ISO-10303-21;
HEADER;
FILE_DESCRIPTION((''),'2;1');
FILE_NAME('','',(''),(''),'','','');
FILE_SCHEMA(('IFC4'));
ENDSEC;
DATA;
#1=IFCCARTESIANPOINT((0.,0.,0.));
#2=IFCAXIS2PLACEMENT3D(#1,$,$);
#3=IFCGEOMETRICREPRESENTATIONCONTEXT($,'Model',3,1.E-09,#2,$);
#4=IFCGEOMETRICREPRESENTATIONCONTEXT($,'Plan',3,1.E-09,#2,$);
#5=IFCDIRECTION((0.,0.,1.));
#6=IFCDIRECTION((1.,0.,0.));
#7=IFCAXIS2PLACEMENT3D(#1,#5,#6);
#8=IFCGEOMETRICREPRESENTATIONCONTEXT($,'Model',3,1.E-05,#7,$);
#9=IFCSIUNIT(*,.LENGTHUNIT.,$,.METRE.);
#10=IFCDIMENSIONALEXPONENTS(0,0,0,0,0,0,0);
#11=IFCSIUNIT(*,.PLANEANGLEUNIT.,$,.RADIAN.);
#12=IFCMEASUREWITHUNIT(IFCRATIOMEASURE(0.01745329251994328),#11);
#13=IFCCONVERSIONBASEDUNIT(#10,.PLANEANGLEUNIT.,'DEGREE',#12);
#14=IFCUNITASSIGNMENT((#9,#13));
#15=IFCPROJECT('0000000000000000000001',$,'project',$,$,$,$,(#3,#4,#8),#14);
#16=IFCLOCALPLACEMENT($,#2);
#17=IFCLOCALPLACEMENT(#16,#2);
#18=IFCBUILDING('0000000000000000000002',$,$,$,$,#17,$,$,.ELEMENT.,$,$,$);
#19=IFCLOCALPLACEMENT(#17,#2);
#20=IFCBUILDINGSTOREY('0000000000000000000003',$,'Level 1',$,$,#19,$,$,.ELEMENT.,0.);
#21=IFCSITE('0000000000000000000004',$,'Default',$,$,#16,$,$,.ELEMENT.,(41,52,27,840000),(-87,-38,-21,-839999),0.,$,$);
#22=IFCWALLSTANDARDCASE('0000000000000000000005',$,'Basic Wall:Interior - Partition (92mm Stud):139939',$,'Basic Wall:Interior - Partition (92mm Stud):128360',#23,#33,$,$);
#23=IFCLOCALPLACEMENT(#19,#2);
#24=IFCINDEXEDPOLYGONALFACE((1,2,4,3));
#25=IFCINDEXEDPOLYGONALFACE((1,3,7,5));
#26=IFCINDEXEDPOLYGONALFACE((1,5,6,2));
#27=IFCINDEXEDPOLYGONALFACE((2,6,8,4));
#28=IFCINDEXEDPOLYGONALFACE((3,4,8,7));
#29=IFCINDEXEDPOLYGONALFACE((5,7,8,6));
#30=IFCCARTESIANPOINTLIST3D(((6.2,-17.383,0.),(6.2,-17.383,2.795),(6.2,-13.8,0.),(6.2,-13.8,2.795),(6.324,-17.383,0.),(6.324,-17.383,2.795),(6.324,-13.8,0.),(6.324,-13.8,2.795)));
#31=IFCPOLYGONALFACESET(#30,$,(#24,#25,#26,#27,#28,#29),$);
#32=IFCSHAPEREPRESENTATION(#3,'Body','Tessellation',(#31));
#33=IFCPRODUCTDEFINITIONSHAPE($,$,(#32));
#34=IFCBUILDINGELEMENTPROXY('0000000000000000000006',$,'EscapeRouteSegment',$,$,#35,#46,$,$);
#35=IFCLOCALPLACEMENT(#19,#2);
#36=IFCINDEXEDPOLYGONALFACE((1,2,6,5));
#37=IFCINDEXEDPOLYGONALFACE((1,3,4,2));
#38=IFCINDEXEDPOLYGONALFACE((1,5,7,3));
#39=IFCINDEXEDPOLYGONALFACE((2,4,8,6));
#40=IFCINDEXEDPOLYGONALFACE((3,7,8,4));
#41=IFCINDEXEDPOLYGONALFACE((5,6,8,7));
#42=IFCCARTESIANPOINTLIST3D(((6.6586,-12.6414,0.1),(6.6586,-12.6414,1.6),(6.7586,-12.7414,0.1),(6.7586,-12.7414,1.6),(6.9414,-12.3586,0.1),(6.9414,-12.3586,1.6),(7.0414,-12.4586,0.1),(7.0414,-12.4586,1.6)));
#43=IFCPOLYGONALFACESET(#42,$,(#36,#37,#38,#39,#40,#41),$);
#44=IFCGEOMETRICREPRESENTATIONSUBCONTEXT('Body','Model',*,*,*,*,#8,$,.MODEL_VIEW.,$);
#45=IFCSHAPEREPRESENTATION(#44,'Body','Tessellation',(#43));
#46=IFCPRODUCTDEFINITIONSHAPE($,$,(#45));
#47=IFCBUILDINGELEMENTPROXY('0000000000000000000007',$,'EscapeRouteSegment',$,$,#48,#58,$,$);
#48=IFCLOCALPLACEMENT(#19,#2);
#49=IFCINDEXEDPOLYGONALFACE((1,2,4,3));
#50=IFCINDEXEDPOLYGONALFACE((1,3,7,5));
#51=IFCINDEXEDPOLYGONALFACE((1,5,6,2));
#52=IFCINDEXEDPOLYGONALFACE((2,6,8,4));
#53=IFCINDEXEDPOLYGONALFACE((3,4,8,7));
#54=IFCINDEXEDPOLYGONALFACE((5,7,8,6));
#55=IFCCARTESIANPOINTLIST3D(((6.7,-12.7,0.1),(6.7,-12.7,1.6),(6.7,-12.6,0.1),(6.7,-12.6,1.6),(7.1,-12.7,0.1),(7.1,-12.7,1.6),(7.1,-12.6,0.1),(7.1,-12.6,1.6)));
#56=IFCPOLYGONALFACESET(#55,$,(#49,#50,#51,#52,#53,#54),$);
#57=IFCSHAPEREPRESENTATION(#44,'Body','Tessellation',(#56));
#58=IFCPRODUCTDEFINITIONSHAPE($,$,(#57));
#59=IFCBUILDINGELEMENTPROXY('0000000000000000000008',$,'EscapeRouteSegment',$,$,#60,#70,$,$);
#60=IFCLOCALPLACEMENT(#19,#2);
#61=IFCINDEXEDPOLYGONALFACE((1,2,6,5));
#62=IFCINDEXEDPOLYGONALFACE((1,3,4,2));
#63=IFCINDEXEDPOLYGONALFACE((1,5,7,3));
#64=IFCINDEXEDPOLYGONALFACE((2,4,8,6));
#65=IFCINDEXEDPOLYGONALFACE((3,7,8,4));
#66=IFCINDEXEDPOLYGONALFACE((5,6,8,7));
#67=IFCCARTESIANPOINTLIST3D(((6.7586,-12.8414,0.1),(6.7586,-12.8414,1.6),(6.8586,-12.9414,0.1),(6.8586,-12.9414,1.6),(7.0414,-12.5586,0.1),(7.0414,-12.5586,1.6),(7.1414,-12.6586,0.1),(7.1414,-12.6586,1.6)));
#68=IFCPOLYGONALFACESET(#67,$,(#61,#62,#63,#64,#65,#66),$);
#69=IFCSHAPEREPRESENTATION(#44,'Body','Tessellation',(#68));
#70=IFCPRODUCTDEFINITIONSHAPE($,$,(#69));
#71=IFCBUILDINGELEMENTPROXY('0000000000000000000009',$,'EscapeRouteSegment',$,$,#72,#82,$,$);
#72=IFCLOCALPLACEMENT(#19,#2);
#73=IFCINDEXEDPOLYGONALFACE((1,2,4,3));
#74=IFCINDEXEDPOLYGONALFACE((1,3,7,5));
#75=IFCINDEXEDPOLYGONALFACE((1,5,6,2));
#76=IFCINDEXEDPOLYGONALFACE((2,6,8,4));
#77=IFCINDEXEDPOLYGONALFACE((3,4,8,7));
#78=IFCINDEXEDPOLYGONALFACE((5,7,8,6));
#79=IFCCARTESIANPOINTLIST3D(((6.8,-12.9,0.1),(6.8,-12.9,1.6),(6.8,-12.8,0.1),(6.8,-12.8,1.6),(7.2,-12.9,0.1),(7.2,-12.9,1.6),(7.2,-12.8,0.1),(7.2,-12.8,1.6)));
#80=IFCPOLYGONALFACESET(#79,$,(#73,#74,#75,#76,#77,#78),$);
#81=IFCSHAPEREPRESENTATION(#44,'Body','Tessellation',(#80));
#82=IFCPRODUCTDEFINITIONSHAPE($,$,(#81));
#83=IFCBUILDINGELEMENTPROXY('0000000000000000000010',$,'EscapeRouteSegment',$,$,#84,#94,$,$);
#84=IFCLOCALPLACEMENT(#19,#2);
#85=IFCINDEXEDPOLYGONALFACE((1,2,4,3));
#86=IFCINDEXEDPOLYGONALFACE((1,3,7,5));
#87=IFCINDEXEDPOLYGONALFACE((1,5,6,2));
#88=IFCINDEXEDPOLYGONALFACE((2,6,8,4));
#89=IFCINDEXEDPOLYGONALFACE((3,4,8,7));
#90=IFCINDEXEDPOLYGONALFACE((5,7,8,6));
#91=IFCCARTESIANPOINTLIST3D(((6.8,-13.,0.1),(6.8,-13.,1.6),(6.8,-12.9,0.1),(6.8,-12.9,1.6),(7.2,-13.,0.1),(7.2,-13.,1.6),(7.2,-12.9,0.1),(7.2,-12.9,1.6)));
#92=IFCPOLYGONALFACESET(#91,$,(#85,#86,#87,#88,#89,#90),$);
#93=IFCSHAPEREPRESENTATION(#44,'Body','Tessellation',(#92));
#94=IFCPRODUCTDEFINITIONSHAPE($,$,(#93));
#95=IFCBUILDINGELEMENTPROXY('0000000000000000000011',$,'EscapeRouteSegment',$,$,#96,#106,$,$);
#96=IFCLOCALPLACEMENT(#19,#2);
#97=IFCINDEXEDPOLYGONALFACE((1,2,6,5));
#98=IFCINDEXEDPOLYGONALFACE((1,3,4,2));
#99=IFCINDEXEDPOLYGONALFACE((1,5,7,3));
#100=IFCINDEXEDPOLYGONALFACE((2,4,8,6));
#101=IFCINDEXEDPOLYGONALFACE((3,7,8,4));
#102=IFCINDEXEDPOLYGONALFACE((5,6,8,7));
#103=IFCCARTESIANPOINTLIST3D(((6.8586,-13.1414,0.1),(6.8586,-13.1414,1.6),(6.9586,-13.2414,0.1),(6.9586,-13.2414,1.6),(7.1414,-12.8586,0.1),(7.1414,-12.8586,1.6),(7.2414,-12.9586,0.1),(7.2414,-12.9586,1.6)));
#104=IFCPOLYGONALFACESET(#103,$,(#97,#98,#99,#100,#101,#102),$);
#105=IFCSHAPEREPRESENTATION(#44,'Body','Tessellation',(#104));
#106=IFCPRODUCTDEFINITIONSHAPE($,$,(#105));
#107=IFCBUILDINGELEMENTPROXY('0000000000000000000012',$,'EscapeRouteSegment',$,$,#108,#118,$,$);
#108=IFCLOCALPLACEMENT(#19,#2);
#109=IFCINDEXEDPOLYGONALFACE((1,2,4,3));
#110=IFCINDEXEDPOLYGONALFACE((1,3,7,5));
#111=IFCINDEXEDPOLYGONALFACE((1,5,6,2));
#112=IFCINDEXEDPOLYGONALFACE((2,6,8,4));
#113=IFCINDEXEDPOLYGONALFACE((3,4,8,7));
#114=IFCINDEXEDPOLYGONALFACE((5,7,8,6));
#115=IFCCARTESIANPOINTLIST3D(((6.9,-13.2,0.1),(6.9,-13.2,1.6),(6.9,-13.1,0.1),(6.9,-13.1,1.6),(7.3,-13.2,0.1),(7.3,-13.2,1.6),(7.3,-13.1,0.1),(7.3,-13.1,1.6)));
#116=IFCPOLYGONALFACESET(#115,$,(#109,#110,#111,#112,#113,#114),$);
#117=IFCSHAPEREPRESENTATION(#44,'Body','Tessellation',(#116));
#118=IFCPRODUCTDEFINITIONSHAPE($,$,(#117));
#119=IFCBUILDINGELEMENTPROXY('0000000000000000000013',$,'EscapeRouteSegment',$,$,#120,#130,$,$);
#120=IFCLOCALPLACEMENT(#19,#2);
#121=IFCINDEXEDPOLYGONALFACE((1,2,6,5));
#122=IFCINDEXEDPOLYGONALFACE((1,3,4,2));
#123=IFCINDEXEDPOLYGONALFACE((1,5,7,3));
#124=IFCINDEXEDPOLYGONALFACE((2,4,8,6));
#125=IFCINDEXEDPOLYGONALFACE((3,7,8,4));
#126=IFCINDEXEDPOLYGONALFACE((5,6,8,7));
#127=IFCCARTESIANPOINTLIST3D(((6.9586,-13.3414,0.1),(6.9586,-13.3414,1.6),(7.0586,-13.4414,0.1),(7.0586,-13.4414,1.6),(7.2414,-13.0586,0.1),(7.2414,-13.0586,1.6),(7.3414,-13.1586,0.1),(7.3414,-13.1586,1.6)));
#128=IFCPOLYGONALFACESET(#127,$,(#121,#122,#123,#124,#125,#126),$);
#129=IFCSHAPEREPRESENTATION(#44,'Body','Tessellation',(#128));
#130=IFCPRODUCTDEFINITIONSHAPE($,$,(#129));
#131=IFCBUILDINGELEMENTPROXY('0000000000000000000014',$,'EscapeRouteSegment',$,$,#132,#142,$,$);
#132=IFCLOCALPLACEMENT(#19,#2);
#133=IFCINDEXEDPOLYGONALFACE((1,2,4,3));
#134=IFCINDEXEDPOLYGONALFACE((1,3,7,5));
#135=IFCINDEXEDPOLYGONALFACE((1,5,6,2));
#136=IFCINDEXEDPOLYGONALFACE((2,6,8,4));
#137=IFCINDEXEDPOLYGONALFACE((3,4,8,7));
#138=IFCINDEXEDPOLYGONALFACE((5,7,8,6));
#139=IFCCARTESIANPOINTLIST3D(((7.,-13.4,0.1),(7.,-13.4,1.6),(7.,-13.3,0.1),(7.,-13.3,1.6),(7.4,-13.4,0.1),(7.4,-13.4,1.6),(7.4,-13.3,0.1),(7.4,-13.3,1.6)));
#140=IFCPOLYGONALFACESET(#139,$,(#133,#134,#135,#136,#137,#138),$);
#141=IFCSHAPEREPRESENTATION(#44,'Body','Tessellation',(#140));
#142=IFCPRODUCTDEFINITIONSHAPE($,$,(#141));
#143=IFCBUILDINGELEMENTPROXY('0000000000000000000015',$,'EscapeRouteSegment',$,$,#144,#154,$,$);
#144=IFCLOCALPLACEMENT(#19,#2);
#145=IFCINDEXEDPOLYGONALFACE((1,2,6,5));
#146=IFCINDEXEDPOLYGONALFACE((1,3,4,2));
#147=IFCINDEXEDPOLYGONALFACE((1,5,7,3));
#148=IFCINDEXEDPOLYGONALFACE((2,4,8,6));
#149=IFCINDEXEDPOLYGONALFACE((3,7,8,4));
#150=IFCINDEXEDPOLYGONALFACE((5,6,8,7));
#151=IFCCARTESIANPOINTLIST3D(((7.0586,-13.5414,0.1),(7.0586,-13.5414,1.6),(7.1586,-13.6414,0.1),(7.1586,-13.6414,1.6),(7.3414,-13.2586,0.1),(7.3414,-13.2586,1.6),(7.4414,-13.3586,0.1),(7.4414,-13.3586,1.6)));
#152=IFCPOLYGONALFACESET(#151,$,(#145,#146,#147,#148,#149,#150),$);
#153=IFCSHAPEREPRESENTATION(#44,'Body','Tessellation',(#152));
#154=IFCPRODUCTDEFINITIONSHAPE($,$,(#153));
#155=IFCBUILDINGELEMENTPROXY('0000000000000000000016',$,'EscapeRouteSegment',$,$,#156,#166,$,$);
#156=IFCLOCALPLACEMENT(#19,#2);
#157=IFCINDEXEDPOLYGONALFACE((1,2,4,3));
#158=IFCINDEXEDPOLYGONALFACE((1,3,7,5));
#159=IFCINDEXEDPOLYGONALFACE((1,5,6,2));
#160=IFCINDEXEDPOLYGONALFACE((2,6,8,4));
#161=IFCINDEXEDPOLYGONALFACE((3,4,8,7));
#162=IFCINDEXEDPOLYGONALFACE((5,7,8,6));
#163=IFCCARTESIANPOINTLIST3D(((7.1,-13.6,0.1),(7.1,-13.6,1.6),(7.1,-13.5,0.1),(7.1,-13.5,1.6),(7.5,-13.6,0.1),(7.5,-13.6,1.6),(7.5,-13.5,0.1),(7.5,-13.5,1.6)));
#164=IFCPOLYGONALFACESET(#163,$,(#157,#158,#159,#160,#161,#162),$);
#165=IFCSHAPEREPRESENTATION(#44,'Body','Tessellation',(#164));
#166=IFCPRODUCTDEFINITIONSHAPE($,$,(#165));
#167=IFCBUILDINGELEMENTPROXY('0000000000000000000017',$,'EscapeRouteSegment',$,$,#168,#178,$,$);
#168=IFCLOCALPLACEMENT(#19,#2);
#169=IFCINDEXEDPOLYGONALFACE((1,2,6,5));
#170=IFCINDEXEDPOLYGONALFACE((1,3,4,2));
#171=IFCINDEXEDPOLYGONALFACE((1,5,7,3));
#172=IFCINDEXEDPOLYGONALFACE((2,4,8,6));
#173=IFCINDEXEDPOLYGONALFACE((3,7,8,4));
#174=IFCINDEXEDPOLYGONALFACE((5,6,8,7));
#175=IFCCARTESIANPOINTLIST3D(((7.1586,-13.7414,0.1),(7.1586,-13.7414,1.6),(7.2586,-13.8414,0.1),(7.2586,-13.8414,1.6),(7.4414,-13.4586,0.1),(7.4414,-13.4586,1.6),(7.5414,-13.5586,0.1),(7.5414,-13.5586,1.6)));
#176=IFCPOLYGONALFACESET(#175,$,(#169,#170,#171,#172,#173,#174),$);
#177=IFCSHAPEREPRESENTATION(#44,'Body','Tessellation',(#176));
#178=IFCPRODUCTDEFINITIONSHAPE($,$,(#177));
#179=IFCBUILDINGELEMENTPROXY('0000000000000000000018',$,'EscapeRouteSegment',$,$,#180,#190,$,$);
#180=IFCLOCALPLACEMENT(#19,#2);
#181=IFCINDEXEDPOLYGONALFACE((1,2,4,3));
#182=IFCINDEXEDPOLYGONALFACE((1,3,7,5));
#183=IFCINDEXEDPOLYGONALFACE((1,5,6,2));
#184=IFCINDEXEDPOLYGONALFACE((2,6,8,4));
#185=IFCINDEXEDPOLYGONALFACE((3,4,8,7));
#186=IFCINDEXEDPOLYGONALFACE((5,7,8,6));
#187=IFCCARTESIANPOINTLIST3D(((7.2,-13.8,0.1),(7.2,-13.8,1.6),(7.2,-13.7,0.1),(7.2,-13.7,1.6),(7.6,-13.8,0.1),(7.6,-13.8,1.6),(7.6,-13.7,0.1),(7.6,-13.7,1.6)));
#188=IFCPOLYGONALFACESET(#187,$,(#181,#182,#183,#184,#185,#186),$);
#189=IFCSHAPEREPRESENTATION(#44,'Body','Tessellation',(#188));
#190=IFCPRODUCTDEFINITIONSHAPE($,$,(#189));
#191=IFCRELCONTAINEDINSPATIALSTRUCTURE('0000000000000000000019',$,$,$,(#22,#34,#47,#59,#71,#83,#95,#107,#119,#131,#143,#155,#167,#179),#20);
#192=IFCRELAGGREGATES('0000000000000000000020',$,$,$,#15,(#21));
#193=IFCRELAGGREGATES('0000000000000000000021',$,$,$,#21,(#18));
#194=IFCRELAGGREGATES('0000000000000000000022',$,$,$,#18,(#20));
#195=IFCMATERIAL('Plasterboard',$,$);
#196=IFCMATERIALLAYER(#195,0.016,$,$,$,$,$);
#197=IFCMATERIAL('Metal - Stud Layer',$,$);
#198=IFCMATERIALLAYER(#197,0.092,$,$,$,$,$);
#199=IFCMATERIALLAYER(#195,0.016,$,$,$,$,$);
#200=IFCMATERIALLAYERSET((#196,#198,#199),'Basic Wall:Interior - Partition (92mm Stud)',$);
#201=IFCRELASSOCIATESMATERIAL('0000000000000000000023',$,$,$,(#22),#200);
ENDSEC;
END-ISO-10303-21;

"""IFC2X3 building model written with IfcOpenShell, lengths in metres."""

from ifc_helpers import new_model, entity, si_unit, converted_unit, frame, frame_2d, origin, origin_with_axes, place, context, subcontext, project, spatial, polyline, rectangle, outline, extrude, material, layer, layer_set, layer_usage, element, save


model = new_model("IFC2X3")

# Units and contexts
model_context_1 = context("Model", 3, precision=1e-09, world=origin())
plan_context = context("Plan", 3, precision=1e-09, world=origin())
model_context_2 = context("Model", 3, precision=1e-05, world=origin_with_axes())
body_context = subcontext(model_context_2, "Body", "Model", "MODEL_VIEW")
ifc_project = project(units=[si_unit("LENGTHUNIT", "METRE"), converted_unit("PLANEANGLEUNIT", "DEGREE", entity("IfcRatioMeasure", 0.01745329251994328), si_unit("PLANEANGLEUNIT", "RADIAN"), dimensions=[0, 0, 0, 0, 0, 0, 0])], contexts=[model_context_1, plan_context, model_context_2])

# Site, building, storey
site_placement = place(None, origin())
site = spatial("IfcSite", under=ifc_project, at=site_placement, Name="Default", CompositionType="ELEMENT", RefLatitude=(41, 52, 27, 840000), RefLongitude=(-87, -38, -21, -839999), RefElevation=0.0)
building_placement = place(site_placement, origin())
building = spatial("IfcBuilding", under=site, at=building_placement, CompositionType="ELEMENT")
storey_placement = place(building_placement, origin())
storey = spatial("IfcBuildingStorey", under=building, at=storey_placement, Name="Level 1", CompositionType="ELEMENT", Elevation=0.0)

# Wall
ifc_material_1 = material(Name="Plasterboard")
ifc_layer_1 = layer(ifc_material_1, 0.016)
ifc_material_2 = material(Name="Metal - Stud Layer")
ifc_layer_2 = layer(ifc_material_2, 0.092)
ifc_layer_3 = layer(ifc_material_1, 0.016)
ifc_layer_set = layer_set([ifc_layer_1, ifc_layer_2, ifc_layer_3], Name="Basic Wall:Interior - Partition (92mm Stud)")
ifc_layer_usage = layer_usage(ifc_layer_set, "AXIS2", "NEGATIVE", 0.062)
wall_placement = place(storey_placement, frame((6.262, -13.8, 0.0), z_axis=(0.0, 0.0, 1.0), x_axis=(0.0, -1.0, 0.0)))
element("IfcWallStandardCase", 1, at=wall_placement, inside=storey, material=ifc_layer_usage, Name="Basic Wall:Interior - Partition (92mm Stud):139939", ObjectType="Basic Wall:Interior - Partition (92mm Stud):128360", context=model_context_1, shape_type="SweptSolid", body=[
    extrude(rectangle(XDim=3.583, YDim=0.124, at=frame_2d((1.7915, 0.0), x_axis=(-1.0, 0.0))), origin(), (0.0, 0.0, 1.0), 2.795),
])

# Building element proxies
proxy_1_placement = place(storey_placement, frame((6.8, -12.5, 0.1), z_axis=(0.0, 0.0, 1.0), x_axis=(0.707105, -0.707108, 0.0)))
element("IfcBuildingElementProxy", 2, at=proxy_1_placement, inside=storey, Name="EscapeRouteSegment", context=body_context, shape_type="SweptSolid", body=[
    extrude(outline(polyline([(0.0, -0.2), (0.0, 0.2), (0.1414, 0.2), (0.1414, -0.2), (0.0, -0.2)])), origin_with_axes(), (0.0, 0.0, 1.0), 1.5),
])
proxy_2_placement = place(storey_placement, frame((6.9, -12.6, 0.1), z_axis=(0.0, 0.0, 1.0), x_axis=(0.0, -1.0, 0.0)))
element("IfcBuildingElementProxy", 3, at=proxy_2_placement, inside=storey, Name="EscapeRouteSegment", context=body_context, shape_type="SweptSolid", body=[
    extrude(outline(polyline([(0.0, -0.2), (0.0, 0.2), (0.1, 0.2), (0.1, -0.2), (0.0, -0.2)])), origin_with_axes(), (0.0, 0.0, 1.0), 1.5),
])
proxy_3_placement = place(storey_placement, frame((6.9, -12.7, 0.1), z_axis=(0.0, 0.0, 1.0), x_axis=(0.707105, -0.707108, 0.0)))
element("IfcBuildingElementProxy", 4, at=proxy_3_placement, inside=storey, Name="EscapeRouteSegment", context=body_context, shape_type="SweptSolid", body=[
    extrude(outline(polyline([(0.0, -0.2), (0.0, 0.2), (0.1414, 0.2), (0.1414, -0.2), (0.0, -0.2)])), origin_with_axes(), (0.0, 0.0, 1.0), 1.5),
])
proxy_4_placement = place(storey_placement, frame((7.0, -12.8, 0.1), z_axis=(0.0, 0.0, 1.0), x_axis=(0.0, -1.0, 0.0)))
element("IfcBuildingElementProxy", 5, at=proxy_4_placement, inside=storey, Name="EscapeRouteSegment", context=body_context, shape_type="SweptSolid", body=[
    extrude(outline(polyline([(0.0, -0.2), (0.0, 0.2), (0.1, 0.2), (0.1, -0.2), (0.0, -0.2)])), origin_with_axes(), (0.0, 0.0, 1.0), 1.5),
])
proxy_5_placement = place(storey_placement, frame((7.0, -12.9, 0.1), z_axis=(0.0, 0.0, 1.0), x_axis=(0.0, -1.0, 0.0)))
element("IfcBuildingElementProxy", 6, at=proxy_5_placement, inside=storey, Name="EscapeRouteSegment", context=body_context, shape_type="SweptSolid", body=[
    extrude(outline(polyline([(0.0, -0.2), (0.0, 0.2), (0.1, 0.2), (0.1, -0.2), (0.0, -0.2)])), origin_with_axes(), (0.0, 0.0, 1.0), 1.5),
])
proxy_6_placement = place(storey_placement, frame((7.0, -13.0, 0.1), z_axis=(0.0, 0.0, 1.0), x_axis=(0.707105, -0.707108, 0.0)))
element("IfcBuildingElementProxy", 7, at=proxy_6_placement, inside=storey, Name="EscapeRouteSegment", context=body_context, shape_type="SweptSolid", body=[
    extrude(outline(polyline([(0.0, -0.2), (0.0, 0.2), (0.1414, 0.2), (0.1414, -0.2), (0.0, -0.2)])), origin_with_axes(), (0.0, 0.0, 1.0), 1.5),
])
proxy_7_placement = place(storey_placement, frame((7.1, -13.1, 0.1), z_axis=(0.0, 0.0, 1.0), x_axis=(0.0, -1.0, 0.0)))
element("IfcBuildingElementProxy", 8, at=proxy_7_placement, inside=storey, Name="EscapeRouteSegment", context=body_context, shape_type="SweptSolid", body=[
    extrude(outline(polyline([(0.0, -0.2), (0.0, 0.2), (0.1, 0.2), (0.1, -0.2), (0.0, -0.2)])), origin_with_axes(), (0.0, 0.0, 1.0), 1.5),
])
proxy_8_placement = place(storey_placement, frame((7.1, -13.2, 0.1), z_axis=(0.0, 0.0, 1.0), x_axis=(0.707105, -0.707108, 0.0)))
element("IfcBuildingElementProxy", 9, at=proxy_8_placement, inside=storey, Name="EscapeRouteSegment", context=body_context, shape_type="SweptSolid", body=[
    extrude(outline(polyline([(0.0, -0.2), (0.0, 0.2), (0.1414, 0.2), (0.1414, -0.2), (0.0, -0.2)])), origin_with_axes(), (0.0, 0.0, 1.0), 1.5),
])
proxy_9_placement = place(storey_placement, frame((7.2, -13.3, 0.1), z_axis=(0.0, 0.0, 1.0), x_axis=(0.0, -1.0, 0.0)))
element("IfcBuildingElementProxy", 10, at=proxy_9_placement, inside=storey, Name="EscapeRouteSegment", context=body_context, shape_type="SweptSolid", body=[
    extrude(outline(polyline([(0.0, -0.2), (0.0, 0.2), (0.1, 0.2), (0.1, -0.2), (0.0, -0.2)])), origin_with_axes(), (0.0, 0.0, 1.0), 1.5),
])
proxy_10_placement = place(storey_placement, frame((7.2, -13.4, 0.1), z_axis=(0.0, 0.0, 1.0), x_axis=(0.707107, -0.707107, 0.0)))
element("IfcBuildingElementProxy", 11, at=proxy_10_placement, inside=storey, Name="EscapeRouteSegment", context=body_context, shape_type="SweptSolid", body=[
    extrude(outline(polyline([(0.0, -0.2), (0.0, 0.2), (0.1414, 0.2), (0.1414, -0.2), (0.0, -0.2)])), origin_with_axes(), (0.0, 0.0, 1.0), 1.5),
])
proxy_11_placement = place(storey_placement, frame((7.3, -13.5, 0.1), z_axis=(0.0, 0.0, 1.0), x_axis=(0.0, -1.0, 0.0)))
element("IfcBuildingElementProxy", 12, at=proxy_11_placement, inside=storey, Name="EscapeRouteSegment", context=body_context, shape_type="SweptSolid", body=[
    extrude(outline(polyline([(0.0, -0.2), (0.0, 0.2), (0.1, 0.2), (0.1, -0.2), (0.0, -0.2)])), origin_with_axes(), (0.0, 0.0, 1.0), 1.5),
])
proxy_12_placement = place(storey_placement, frame((7.3, -13.6, 0.1), z_axis=(0.0, 0.0, 1.0), x_axis=(0.707108, -0.707105, 0.0)))
element("IfcBuildingElementProxy", 13, at=proxy_12_placement, inside=storey, Name="EscapeRouteSegment", context=body_context, shape_type="SweptSolid", body=[
    extrude(outline(polyline([(0.0, -0.2), (0.0, 0.2), (0.1414, 0.2), (0.1414, -0.2), (0.0, -0.2)])), origin_with_axes(), (0.0, 0.0, 1.0), 1.5),
])
proxy_13_placement = place(storey_placement, frame((7.4, -13.7, 0.1), z_axis=(0.0, 0.0, 1.0), x_axis=(0.0, -1.0, 0.0)))
element("IfcBuildingElementProxy", 14, at=proxy_13_placement, inside=storey, Name="EscapeRouteSegment", context=body_context, shape_type="SweptSolid", body=[
    extrude(outline(polyline([(0.0, -0.2), (0.0, 0.2), (0.1, 0.2), (0.1, -0.2), (0.0, -0.2)])), origin_with_axes(), (0.0, 0.0, 1.0), 1.5),
])

save(model, "model.ifc")
